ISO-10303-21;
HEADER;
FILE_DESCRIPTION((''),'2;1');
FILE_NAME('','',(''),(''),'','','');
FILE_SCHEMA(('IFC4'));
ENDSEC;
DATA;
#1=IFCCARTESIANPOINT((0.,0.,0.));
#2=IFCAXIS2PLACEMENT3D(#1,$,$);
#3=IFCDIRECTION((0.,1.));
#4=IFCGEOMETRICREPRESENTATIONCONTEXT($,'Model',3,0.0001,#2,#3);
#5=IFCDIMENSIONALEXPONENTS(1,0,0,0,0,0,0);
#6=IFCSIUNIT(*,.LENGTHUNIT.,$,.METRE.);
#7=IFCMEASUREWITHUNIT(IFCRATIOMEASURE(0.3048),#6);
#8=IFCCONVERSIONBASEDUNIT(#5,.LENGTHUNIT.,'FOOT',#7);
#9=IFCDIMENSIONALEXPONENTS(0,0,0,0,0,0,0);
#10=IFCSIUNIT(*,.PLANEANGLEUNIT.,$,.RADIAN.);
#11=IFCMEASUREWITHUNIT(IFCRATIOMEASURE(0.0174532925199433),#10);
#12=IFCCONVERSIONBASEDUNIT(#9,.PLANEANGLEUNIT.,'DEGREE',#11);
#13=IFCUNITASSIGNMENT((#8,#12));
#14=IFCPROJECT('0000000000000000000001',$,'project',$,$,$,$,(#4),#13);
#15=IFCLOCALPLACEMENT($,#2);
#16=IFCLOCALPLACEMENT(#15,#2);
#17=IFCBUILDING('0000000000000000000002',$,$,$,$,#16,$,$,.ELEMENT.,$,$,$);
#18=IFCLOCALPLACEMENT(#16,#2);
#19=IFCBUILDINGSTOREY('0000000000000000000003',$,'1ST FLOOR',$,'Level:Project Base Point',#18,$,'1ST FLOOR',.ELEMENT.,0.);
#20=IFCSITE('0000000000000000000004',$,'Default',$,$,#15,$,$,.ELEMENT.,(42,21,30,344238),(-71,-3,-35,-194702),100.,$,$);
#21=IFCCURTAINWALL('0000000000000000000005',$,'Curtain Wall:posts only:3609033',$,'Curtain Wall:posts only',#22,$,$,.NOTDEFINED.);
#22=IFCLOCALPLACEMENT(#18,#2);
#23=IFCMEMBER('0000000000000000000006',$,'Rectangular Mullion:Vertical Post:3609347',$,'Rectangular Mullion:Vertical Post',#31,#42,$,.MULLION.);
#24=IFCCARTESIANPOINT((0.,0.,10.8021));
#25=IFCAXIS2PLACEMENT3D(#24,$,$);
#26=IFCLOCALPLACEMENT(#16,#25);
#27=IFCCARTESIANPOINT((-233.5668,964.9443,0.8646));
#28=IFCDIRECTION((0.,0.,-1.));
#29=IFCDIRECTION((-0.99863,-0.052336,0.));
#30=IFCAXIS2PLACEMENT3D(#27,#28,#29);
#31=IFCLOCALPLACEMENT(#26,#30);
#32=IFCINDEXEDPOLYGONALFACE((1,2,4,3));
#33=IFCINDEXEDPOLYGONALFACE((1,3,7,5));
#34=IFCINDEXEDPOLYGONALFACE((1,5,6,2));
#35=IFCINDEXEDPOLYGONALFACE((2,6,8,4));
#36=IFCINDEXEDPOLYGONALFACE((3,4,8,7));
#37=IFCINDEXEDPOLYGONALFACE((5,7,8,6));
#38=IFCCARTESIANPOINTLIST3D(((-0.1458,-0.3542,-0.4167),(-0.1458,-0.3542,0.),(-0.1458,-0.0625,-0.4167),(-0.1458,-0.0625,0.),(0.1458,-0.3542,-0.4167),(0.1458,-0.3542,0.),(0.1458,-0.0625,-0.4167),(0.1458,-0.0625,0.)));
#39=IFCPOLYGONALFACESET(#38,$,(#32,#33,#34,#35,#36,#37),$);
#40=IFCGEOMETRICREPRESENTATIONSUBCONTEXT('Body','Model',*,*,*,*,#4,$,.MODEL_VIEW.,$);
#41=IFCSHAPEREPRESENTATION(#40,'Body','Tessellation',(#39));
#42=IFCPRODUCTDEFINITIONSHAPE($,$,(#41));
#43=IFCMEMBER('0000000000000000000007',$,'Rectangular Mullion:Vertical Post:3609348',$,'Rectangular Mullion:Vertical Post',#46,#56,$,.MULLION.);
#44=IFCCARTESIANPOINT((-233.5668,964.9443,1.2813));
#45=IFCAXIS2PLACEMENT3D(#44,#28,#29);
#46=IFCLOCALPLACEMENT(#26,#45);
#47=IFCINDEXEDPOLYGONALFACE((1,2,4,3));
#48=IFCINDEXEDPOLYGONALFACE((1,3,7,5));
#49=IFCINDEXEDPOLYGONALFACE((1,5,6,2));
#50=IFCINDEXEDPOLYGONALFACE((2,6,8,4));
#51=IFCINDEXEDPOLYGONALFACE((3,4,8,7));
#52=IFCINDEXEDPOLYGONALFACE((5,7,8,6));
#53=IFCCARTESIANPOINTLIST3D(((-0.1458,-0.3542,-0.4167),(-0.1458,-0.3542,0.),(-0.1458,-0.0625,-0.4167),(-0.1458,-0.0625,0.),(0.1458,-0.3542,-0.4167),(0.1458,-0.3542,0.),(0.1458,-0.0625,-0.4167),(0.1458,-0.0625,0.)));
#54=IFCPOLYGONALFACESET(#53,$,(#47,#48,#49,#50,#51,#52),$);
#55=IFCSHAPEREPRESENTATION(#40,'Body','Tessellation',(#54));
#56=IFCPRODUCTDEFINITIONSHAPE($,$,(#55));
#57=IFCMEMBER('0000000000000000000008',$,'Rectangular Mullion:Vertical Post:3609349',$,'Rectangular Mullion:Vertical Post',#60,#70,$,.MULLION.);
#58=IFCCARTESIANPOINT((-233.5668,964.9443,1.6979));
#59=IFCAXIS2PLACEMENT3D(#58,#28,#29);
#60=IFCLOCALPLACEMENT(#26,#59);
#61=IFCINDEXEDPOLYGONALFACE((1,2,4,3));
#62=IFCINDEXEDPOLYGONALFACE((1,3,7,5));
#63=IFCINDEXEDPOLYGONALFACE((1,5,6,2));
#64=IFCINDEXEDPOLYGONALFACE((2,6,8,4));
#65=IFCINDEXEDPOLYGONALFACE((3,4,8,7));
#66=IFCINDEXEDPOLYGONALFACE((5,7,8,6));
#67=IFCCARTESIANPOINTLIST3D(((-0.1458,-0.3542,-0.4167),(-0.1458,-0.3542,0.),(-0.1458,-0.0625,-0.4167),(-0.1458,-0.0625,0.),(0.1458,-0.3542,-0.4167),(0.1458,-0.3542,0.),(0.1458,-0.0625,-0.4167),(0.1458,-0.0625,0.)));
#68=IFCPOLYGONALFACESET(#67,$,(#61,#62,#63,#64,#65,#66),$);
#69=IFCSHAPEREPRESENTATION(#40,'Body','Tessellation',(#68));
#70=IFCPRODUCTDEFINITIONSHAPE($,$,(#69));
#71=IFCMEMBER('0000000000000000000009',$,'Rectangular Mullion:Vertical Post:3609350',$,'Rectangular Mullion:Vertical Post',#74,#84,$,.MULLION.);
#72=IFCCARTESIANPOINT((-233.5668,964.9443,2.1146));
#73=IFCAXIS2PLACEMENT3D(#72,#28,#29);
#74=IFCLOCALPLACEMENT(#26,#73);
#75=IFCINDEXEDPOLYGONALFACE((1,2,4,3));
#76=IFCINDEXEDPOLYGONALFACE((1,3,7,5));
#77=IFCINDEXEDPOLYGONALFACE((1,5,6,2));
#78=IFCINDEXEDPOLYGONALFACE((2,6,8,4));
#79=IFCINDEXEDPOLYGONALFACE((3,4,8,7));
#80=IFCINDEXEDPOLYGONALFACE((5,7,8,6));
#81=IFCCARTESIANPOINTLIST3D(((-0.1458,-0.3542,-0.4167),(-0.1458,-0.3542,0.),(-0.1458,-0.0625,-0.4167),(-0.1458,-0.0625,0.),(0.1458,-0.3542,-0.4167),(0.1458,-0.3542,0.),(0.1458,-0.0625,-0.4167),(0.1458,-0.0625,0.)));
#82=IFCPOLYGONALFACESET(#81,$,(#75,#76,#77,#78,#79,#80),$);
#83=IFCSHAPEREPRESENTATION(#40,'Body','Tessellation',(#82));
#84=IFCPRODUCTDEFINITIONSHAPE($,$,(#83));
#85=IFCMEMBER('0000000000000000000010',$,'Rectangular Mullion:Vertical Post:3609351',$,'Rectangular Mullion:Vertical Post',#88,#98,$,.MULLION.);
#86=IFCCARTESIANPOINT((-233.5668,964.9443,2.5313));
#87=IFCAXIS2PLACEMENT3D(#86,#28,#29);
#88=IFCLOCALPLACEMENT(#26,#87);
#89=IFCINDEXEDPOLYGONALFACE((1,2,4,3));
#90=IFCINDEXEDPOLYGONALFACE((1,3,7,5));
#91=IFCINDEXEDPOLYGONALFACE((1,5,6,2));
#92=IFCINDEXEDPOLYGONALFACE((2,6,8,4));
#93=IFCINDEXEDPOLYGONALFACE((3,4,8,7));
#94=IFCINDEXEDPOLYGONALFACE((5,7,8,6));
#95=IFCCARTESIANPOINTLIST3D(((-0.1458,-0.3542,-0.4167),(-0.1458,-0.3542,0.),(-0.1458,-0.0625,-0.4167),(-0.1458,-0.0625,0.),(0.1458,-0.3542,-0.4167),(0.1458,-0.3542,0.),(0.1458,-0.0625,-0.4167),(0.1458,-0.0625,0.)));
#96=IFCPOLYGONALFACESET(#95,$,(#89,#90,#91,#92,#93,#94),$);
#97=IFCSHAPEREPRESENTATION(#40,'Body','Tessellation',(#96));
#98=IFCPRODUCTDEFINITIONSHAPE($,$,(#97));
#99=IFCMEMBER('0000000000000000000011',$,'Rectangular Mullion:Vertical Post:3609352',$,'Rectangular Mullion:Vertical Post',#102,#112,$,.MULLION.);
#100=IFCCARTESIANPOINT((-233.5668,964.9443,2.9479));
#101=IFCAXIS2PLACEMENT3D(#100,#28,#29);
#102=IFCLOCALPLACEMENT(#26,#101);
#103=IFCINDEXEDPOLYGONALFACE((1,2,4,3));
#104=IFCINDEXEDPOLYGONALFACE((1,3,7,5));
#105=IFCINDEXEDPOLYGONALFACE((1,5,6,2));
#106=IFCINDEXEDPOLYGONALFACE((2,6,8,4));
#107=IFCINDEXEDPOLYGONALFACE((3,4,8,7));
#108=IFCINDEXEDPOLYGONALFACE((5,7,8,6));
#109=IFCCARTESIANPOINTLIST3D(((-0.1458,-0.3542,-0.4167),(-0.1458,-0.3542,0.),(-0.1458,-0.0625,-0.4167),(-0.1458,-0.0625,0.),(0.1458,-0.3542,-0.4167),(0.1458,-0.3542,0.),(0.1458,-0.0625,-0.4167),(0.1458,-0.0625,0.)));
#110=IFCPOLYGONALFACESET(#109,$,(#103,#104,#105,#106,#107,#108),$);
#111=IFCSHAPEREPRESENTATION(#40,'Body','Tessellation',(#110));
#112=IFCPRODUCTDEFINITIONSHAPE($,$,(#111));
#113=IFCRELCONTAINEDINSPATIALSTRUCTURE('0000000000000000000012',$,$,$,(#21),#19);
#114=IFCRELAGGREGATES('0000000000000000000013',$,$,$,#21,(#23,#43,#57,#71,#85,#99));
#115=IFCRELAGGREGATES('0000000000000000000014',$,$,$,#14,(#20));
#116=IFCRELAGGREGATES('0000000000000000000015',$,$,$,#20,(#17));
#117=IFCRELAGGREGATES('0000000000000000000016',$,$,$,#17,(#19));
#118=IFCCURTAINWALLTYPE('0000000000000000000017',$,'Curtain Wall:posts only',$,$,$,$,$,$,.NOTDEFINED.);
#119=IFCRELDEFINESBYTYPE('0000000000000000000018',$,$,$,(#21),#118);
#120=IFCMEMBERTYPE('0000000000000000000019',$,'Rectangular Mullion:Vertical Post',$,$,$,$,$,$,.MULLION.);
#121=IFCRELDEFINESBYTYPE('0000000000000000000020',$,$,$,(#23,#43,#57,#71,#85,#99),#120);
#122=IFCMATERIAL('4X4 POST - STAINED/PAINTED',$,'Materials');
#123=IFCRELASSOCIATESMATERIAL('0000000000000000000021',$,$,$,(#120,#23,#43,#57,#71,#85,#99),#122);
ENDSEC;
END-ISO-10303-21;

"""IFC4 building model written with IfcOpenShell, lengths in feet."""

from ifc_helpers import new_model, entity, si_unit, converted_unit, direction, frame, origin, origin_2d_with_axis, place, context, subcontext, project, spatial, rectangle, extrude, source, transform, mapped, material, material_profile, profile_set, profile_usage, type_object, type_shapes, element, aggregate, save


model = new_model("IFC4")

# Units and contexts
model_context = context("Model", 3, precision=0.0001, world=origin(), true_north=direction((0.0, 1.0)))
body_context = subcontext(model_context, "Body", "Model", "MODEL_VIEW")
ifc_project = project(units=[converted_unit("LENGTHUNIT", "FOOT", entity("IfcRatioMeasure", 0.3048), si_unit("LENGTHUNIT", "METRE"), dimensions=[1, 0, 0, 0, 0, 0, 0]), converted_unit("PLANEANGLEUNIT", "DEGREE", entity("IfcRatioMeasure", 0.0174532925199433), si_unit("PLANEANGLEUNIT", "RADIAN"), dimensions=[0, 0, 0, 0, 0, 0, 0])], contexts=[model_context])

# Site, building, storey
site_placement = place(None, origin())
site = spatial("IfcSite", under=ifc_project, at=site_placement, Name="Default", CompositionType="ELEMENT", RefLatitude=(42, 21, 30, 344238), RefLongitude=(-71, -3, -35, -194702), RefElevation=100.0)
building_placement = place(site_placement, origin())
building = spatial("IfcBuilding", under=site, at=building_placement, CompositionType="ELEMENT")
storey_placement = place(building_placement, origin())
storey = spatial("IfcBuildingStorey", under=building, at=storey_placement, Name="1ST FLOOR", ObjectType="Level:Project Base Point", LongName="1ST FLOOR", CompositionType="ELEMENT", Elevation=0.0)

# Curtain wall, members
curtain_wall_type_1 = type_object("IfcCurtainWallType", Name="Curtain Wall:posts only", PredefinedType="NOTDEFINED")
curtain_wall_1_placement = place(storey_placement, origin())
curtain_wall_1 = element("IfcCurtainWall", 1, at=curtain_wall_1_placement, inside=storey, type_object=curtain_wall_type_1, Name="Curtain Wall:posts only:3609033", ObjectType="Curtain Wall:posts only", PredefinedType="NOTDEFINED")
ifc_material_1 = material(Name="4X4 POST - STAINED/PAINTED", Category="Materials")
ifc_material_profile_1 = material_profile(ifc_material_1, rectangle(XDim=0.2917, YDim=0.2917, at=origin_2d_with_axis()), Name="Vertical Post")
ifc_profile_set_1 = profile_set([ifc_material_profile_1], Name="Vertical Post")
member_type_1 = type_object("IfcMemberType", Name="Rectangular Mullion:Vertical Post", PredefinedType="MULLION", material=ifc_profile_set_1)
shared_shape_1 = source(origin(), body_context, "Body", "SweptSolid", [
    extrude(rectangle(XDim=0.2917, YDim=0.2917, at=origin_2d_with_axis()), frame((0.0, -0.2083, -0.4167), z_axis=(0.0, 0.0, 1.0), x_axis=(0.0, -1.0, 0.0)), (0.0, 0.0, 1.0), 0.4167),
])
type_shapes(member_type_1, [shared_shape_1])
placement = place(building_placement, frame((0.0, 0.0, 10.8021)))
ifc_profile_usage_1 = profile_usage(ifc_profile_set_1)
member_1_placement = place(placement, frame((-233.5668, 964.9443, 0.8646), z_axis=(0.0, 0.0, -1.0), x_axis=(-0.99863, -0.052336, 0.0)))
member_1 = element("IfcMember", 2, at=member_1_placement, type_object=member_type_1, material=ifc_profile_usage_1, Name="Rectangular Mullion:Vertical Post:3609347", ObjectType="Rectangular Mullion:Vertical Post", PredefinedType="MULLION", context=body_context, shape_type="MappedRepresentation", body=[
    mapped(shared_shape_1, transform((0.0, 0.0, 0.0), scale=1.0)),
])
ifc_profile_usage_2 = profile_usage(ifc_profile_set_1)
member_2_placement = place(placement, frame((-233.5668, 964.9443, 1.2813), z_axis=(0.0, 0.0, -1.0), x_axis=(-0.99863, -0.052336, 0.0)))
member_2 = element("IfcMember", 3, at=member_2_placement, type_object=member_type_1, material=ifc_profile_usage_2, Name="Rectangular Mullion:Vertical Post:3609348", ObjectType="Rectangular Mullion:Vertical Post", PredefinedType="MULLION", context=body_context, shape_type="MappedRepresentation", body=[
    mapped(shared_shape_1, transform((0.0, 0.0, 0.0), scale=1.0)),
])
ifc_profile_usage_3 = profile_usage(ifc_profile_set_1)
member_3_placement = place(placement, frame((-233.5668, 964.9443, 1.6979), z_axis=(0.0, 0.0, -1.0), x_axis=(-0.99863, -0.052336, 0.0)))
member_3 = element("IfcMember", 4, at=member_3_placement, type_object=member_type_1, material=ifc_profile_usage_3, Name="Rectangular Mullion:Vertical Post:3609349", ObjectType="Rectangular Mullion:Vertical Post", PredefinedType="MULLION", context=body_context, shape_type="MappedRepresentation", body=[
    mapped(shared_shape_1, transform((0.0, 0.0, 0.0), scale=1.0)),
])
ifc_profile_usage_4 = profile_usage(ifc_profile_set_1)
member_4_placement = place(placement, frame((-233.5668, 964.9443, 2.1146), z_axis=(0.0, 0.0, -1.0), x_axis=(-0.99863, -0.052336, 0.0)))
member_4 = element("IfcMember", 5, at=member_4_placement, type_object=member_type_1, material=ifc_profile_usage_4, Name="Rectangular Mullion:Vertical Post:3609350", ObjectType="Rectangular Mullion:Vertical Post", PredefinedType="MULLION", context=body_context, shape_type="MappedRepresentation", body=[
    mapped(shared_shape_1, transform((0.0, 0.0, 0.0), scale=1.0)),
])
ifc_profile_usage_5 = profile_usage(ifc_profile_set_1)
member_5_placement = place(placement, frame((-233.5668, 964.9443, 2.5313), z_axis=(0.0, 0.0, -1.0), x_axis=(-0.99863, -0.052336, 0.0)))
member_5 = element("IfcMember", 6, at=member_5_placement, type_object=member_type_1, material=ifc_profile_usage_5, Name="Rectangular Mullion:Vertical Post:3609351", ObjectType="Rectangular Mullion:Vertical Post", PredefinedType="MULLION", context=body_context, shape_type="MappedRepresentation", body=[
    mapped(shared_shape_1, transform((0.0, 0.0, 0.0), scale=1.0)),
])
ifc_profile_usage_6 = profile_usage(ifc_profile_set_1)
member_6_placement = place(placement, frame((-233.5668, 964.9443, 2.9479), z_axis=(0.0, 0.0, -1.0), x_axis=(-0.99863, -0.052336, 0.0)))
member_6 = element("IfcMember", 7, at=member_6_placement, type_object=member_type_1, material=ifc_profile_usage_6, Name="Rectangular Mullion:Vertical Post:3609352", ObjectType="Rectangular Mullion:Vertical Post", PredefinedType="MULLION", context=body_context, shape_type="MappedRepresentation", body=[
    mapped(shared_shape_1, transform((0.0, 0.0, 0.0), scale=1.0)),
])
aggregate(curtain_wall_1, [member_1, member_2, member_3, member_4, member_5, member_6])

save(model, "model.ifc")
